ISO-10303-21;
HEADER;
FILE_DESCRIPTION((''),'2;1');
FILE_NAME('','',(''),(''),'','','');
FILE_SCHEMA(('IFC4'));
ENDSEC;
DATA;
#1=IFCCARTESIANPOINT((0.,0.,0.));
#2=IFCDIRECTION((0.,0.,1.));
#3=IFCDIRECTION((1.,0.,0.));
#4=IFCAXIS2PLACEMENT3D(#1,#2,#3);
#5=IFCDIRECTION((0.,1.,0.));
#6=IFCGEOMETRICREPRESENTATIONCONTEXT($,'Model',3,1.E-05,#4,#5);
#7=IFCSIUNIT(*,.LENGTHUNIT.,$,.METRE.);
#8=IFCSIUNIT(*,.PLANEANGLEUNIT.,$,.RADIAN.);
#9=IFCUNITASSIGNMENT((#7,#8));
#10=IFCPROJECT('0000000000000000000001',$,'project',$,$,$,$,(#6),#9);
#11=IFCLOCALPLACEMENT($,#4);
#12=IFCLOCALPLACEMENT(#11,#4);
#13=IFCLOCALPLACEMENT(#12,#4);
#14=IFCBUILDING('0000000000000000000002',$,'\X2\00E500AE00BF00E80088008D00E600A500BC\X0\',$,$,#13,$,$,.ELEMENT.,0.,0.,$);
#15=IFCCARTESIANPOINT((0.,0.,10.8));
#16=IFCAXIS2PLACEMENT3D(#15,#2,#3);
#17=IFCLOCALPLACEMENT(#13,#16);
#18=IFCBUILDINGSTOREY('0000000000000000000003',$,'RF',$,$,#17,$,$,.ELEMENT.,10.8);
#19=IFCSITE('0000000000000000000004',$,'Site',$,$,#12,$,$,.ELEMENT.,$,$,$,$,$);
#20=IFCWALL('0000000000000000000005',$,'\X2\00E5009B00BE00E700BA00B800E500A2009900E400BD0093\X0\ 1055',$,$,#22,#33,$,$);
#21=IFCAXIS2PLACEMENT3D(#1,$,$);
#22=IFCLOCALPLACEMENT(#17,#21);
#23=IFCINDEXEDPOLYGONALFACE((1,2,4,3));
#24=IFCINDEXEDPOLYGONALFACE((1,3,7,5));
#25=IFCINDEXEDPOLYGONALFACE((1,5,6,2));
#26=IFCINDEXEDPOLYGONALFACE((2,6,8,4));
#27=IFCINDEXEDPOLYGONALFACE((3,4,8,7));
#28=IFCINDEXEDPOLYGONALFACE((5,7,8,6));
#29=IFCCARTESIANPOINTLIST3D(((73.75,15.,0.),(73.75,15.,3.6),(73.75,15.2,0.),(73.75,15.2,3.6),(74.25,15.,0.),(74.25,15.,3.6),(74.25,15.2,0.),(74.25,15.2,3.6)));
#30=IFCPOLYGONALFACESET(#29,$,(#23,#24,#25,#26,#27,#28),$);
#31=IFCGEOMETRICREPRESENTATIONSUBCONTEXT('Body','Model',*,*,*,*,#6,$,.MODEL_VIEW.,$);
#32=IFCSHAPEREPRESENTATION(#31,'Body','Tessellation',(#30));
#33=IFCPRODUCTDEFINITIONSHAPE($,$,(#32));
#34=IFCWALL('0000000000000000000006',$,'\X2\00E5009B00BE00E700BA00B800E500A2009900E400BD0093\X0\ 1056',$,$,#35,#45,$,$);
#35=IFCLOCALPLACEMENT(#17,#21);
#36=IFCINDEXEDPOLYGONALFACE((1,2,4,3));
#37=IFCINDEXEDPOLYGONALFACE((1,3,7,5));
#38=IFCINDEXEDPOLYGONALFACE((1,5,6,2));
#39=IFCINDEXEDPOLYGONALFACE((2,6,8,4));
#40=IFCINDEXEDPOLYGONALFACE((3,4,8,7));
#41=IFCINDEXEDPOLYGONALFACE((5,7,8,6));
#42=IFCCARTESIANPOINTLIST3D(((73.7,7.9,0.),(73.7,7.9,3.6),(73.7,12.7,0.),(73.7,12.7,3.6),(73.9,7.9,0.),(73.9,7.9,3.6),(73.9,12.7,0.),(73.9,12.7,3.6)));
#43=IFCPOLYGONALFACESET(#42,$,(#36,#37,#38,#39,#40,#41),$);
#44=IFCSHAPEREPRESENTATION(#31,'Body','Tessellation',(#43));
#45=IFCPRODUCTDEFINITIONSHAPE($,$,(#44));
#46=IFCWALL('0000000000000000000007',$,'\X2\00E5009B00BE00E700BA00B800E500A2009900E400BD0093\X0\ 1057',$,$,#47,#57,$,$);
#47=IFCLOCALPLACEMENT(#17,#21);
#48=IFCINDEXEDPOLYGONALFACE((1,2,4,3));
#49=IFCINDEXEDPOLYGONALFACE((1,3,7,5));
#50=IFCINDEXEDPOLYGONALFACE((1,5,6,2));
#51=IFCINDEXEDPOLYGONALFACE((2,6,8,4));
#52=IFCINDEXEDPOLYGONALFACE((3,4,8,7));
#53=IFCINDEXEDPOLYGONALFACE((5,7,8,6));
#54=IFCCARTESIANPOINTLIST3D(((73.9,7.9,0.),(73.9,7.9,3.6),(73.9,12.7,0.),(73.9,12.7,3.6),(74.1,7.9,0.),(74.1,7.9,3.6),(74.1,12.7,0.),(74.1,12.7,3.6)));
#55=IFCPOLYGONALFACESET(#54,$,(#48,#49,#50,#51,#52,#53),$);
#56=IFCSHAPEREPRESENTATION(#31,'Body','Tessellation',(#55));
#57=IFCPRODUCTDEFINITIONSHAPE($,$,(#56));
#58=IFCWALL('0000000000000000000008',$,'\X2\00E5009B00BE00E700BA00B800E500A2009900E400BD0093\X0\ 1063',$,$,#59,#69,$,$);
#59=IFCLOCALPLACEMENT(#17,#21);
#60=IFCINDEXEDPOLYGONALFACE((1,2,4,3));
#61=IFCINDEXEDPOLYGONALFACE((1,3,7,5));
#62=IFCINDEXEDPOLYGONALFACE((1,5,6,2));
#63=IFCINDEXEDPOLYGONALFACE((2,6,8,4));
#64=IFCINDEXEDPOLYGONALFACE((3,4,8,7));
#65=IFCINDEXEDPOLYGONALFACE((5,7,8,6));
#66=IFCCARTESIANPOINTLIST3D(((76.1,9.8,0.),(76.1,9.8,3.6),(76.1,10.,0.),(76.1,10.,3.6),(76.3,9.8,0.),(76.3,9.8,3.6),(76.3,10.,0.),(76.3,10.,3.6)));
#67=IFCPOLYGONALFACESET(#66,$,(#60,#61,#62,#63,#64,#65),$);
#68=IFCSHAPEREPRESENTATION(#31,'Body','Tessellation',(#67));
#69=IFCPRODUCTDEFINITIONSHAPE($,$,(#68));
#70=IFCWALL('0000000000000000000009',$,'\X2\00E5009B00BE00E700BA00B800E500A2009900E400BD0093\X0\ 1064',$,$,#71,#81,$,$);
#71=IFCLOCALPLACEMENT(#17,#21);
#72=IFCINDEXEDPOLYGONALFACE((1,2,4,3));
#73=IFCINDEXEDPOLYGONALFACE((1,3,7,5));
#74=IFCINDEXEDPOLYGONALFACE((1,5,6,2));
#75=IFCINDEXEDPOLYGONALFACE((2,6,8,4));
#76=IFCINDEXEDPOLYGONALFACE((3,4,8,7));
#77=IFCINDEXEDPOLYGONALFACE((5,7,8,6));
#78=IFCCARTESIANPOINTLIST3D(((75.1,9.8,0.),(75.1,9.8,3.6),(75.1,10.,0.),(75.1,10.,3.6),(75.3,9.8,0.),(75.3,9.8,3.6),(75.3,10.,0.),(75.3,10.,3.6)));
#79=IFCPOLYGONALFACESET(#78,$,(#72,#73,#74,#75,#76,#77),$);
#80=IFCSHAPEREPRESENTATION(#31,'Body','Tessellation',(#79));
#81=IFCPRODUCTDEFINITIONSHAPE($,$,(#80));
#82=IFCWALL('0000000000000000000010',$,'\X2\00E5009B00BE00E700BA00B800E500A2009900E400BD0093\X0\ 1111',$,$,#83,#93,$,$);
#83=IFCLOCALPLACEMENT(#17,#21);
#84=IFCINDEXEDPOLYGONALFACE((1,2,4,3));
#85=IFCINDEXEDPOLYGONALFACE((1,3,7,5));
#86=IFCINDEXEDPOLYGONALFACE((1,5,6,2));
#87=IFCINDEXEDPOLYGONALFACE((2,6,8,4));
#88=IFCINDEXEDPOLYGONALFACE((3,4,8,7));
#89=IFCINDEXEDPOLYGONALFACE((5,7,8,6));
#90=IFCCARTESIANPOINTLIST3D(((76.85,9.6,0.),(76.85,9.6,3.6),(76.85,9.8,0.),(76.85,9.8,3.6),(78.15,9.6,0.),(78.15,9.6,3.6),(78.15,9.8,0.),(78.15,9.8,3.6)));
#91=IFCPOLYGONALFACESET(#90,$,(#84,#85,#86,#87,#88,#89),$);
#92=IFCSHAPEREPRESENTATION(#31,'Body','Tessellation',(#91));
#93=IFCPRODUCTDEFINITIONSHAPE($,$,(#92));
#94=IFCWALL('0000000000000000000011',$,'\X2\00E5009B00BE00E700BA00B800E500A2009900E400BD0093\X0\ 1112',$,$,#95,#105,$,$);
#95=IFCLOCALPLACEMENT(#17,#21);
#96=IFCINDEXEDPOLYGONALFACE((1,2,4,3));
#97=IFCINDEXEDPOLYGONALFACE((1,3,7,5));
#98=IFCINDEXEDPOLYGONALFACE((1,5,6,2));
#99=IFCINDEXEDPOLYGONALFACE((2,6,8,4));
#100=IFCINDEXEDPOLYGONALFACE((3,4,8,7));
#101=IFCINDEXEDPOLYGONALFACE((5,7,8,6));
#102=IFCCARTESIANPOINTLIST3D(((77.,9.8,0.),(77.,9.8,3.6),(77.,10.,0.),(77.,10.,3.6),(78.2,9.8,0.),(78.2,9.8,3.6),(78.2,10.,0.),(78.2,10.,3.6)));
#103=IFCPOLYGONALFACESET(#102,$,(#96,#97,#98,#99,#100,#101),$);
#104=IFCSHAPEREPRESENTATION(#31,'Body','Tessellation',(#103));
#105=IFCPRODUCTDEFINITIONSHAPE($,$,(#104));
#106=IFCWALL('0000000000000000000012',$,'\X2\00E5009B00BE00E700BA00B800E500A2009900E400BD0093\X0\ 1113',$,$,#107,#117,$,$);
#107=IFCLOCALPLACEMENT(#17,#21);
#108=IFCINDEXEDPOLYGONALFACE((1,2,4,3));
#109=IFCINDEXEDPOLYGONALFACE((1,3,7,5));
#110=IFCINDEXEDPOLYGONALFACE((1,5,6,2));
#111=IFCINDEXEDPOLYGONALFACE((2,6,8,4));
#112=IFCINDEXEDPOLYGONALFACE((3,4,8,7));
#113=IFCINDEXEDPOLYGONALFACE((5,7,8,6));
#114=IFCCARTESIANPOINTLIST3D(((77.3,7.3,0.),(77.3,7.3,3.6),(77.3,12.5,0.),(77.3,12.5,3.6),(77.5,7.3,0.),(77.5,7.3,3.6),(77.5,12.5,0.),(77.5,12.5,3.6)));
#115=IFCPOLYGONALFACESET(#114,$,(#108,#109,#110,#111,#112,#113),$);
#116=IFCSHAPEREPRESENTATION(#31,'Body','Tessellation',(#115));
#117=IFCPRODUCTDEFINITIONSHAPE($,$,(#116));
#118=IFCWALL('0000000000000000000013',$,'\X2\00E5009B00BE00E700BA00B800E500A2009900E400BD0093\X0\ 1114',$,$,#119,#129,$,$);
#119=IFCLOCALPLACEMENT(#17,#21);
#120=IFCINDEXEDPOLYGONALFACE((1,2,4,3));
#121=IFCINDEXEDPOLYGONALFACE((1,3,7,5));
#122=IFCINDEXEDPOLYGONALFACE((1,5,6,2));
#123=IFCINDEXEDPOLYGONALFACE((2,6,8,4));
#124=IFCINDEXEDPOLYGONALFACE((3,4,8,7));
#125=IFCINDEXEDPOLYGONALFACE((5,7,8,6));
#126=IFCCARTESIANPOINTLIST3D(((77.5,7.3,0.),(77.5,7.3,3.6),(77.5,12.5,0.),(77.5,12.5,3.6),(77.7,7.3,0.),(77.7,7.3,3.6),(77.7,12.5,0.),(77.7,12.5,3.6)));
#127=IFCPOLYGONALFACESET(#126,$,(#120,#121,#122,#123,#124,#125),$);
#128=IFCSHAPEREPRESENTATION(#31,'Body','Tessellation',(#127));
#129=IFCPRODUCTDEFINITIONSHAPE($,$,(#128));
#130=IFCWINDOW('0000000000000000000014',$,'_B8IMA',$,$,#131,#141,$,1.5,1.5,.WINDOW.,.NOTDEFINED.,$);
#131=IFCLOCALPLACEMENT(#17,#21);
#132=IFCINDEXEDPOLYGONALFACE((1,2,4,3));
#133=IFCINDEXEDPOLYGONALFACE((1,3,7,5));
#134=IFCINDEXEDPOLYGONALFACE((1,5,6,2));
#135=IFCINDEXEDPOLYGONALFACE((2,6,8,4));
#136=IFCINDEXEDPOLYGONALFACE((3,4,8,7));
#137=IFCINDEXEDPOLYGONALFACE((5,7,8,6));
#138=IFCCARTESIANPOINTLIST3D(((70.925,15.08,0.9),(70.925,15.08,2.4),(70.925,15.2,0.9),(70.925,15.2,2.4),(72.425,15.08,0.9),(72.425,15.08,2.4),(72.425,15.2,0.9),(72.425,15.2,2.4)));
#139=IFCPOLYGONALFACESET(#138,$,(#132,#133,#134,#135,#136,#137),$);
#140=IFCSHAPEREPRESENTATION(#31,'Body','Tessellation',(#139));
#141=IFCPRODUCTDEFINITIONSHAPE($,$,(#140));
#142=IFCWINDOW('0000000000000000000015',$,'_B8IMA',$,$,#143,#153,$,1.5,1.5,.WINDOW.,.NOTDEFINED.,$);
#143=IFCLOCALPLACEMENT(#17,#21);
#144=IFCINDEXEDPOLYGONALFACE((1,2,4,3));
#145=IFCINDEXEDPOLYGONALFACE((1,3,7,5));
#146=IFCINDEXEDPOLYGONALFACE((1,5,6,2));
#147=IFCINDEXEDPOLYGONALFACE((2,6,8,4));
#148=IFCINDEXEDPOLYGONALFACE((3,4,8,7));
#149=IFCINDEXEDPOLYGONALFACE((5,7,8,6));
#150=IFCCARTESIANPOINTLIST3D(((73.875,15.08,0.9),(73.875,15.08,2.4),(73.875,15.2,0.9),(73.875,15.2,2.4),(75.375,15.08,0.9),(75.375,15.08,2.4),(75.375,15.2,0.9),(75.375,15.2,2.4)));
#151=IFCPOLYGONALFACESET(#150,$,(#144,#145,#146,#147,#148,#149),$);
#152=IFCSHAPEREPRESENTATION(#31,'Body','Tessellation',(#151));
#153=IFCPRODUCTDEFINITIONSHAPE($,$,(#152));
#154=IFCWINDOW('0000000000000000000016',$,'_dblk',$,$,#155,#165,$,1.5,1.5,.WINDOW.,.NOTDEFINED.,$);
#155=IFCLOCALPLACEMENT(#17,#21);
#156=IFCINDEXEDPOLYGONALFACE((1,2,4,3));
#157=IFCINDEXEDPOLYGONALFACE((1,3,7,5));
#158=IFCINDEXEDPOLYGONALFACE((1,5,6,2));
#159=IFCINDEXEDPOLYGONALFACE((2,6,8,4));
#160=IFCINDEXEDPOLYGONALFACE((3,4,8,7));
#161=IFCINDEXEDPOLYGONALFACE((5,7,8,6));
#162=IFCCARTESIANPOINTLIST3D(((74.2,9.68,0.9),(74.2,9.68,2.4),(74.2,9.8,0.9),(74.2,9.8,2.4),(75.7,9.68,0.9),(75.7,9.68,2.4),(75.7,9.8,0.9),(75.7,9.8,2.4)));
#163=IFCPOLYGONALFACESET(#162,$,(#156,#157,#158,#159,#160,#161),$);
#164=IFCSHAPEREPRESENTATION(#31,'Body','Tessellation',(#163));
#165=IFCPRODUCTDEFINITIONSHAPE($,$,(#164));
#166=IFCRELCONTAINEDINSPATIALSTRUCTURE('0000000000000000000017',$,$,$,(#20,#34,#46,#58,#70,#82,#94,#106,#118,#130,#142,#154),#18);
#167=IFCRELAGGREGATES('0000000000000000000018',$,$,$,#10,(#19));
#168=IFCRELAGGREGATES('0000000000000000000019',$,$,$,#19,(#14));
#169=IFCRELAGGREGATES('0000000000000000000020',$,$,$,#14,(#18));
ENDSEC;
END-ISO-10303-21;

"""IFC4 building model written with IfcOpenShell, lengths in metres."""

from ifc_helpers import new_model, si_unit, direction, frame, frame_2d, origin_with_axes, place, context, subcontext, project, spatial, rectangle, extrude, element, save


model = new_model("IFC4")

# Units and contexts
model_context = context("Model", 3, precision=1e-05, world=origin_with_axes(), true_north=direction((0.0, 1.0, 0.0)))
body_context = subcontext(model_context, "Body", "Model", "MODEL_VIEW")
ifc_project = project(units=[si_unit("LENGTHUNIT", "METRE"), si_unit("PLANEANGLEUNIT", "RADIAN")], contexts=[model_context])

# Site, building, storey
placement = place(None, origin_with_axes())
site_placement = place(placement, origin_with_axes())
site = spatial("IfcSite", under=ifc_project, at=site_placement, Name="Site", CompositionType="ELEMENT")
building_placement = place(site_placement, origin_with_axes())
building = spatial("IfcBuilding", under=site, at=building_placement, Name="å®¿è\u0088\u008dæ¥¼", CompositionType="ELEMENT", ElevationOfRefHeight=0.0, ElevationOfTerrain=0.0)
storey_placement = place(building_placement, frame((0.0, 0.0, 10.8), z_axis=(0.0, 0.0, 1.0), x_axis=(1.0, 0.0, 0.0)))
storey = spatial("IfcBuildingStorey", under=building, at=storey_placement, Name="RF", CompositionType="ELEMENT", Elevation=10.8)

# Walls
for number, where, z_axis, x_axis, name in (
    (1, (74.0, 15.1, 0.0), (0.0, 0.0, 1.0), (1.0, 0.0, 0.0), "å\u009b¾çº¸å¢\u0099ä½\u0093 1055"),
):
    element("IfcWall", number, at=place(storey_placement, frame(where, z_axis=z_axis, x_axis=x_axis)), inside=storey, Name=name, context=body_context, shape_type="SweptSolid", body=[
        extrude(rectangle(XDim=0.5, YDim=0.2, at=frame_2d((0.0, 0.0), x_axis=(1.0, 0.0, 0.0))), frame((0.0, 0.0, 0.0), z_axis=(0.0, 0.0, 1.0)), (0.0, 0.0, 1.0), 3.6),
    ])
for number, where, z_axis, x_axis, name in (
    (2, (73.8, 10.3, 0.0), (0.0, 0.0, 1.0), (0.0, 1.0, 0.0), "å\u009b¾çº¸å¢\u0099ä½\u0093 1056"),
    (3, (74.0, 10.3, 0.0), (0.0, 0.0, 1.0), (0.0, 1.0, 0.0), "å\u009b¾çº¸å¢\u0099ä½\u0093 1057"),
):
    element("IfcWall", number, at=place(storey_placement, frame(where, z_axis=z_axis, x_axis=x_axis)), inside=storey, Name=name, context=body_context, shape_type="SweptSolid", body=[
        extrude(rectangle(XDim=4.8, YDim=0.2, at=frame_2d((0.0, 0.0), x_axis=(1.0, 0.0, 0.0))), frame((0.0, 0.0, 0.0), z_axis=(0.0, 0.0, 1.0)), (0.0, 0.0, 1.0), 3.6),
    ])
for number, where, z_axis, x_axis, name in (
    (4, (76.2, 9.9, 0.0), (0.0, 0.0, 1.0), (0.0, -1.0, 0.0), "å\u009b¾çº¸å¢\u0099ä½\u0093 1063"),
    (5, (75.2, 9.9, 0.0), (0.0, 0.0, 1.0), (0.0, -1.0, 0.0), "å\u009b¾çº¸å¢\u0099ä½\u0093 1064"),
):
    element("IfcWall", number, at=place(storey_placement, frame(where, z_axis=z_axis, x_axis=x_axis)), inside=storey, Name=name, context=body_context, shape_type="SweptSolid", body=[
        extrude(rectangle(XDim=0.2, YDim=0.2, at=frame_2d((0.0, 0.0), x_axis=(1.0, 0.0, 0.0))), frame((0.0, 0.0, 0.0), z_axis=(0.0, 0.0, 1.0)), (0.0, 0.0, 1.0), 3.6),
    ])
wall_1_placement = place(storey_placement, frame((77.5, 9.7, 0.0), z_axis=(0.0, 0.0, 1.0), x_axis=(1.0, 0.0, 0.0)))
element("IfcWall", 6, at=wall_1_placement, inside=storey, Name="å\u009b¾çº¸å¢\u0099ä½\u0093 1111", context=body_context, shape_type="SweptSolid", body=[
    extrude(rectangle(XDim=1.3, YDim=0.2, at=frame_2d((0.0, 0.0), x_axis=(1.0, 0.0, 0.0))), frame((0.0, 0.0, 0.0), z_axis=(0.0, 0.0, 1.0)), (0.0, 0.0, 1.0), 3.6),
])
wall_2_placement = place(storey_placement, frame((77.6, 9.9, 0.0), z_axis=(0.0, 0.0, 1.0), x_axis=(1.0, 0.0, 0.0)))
element("IfcWall", 7, at=wall_2_placement, inside=storey, Name="å\u009b¾çº¸å¢\u0099ä½\u0093 1112", context=body_context, shape_type="SweptSolid", body=[
    extrude(rectangle(XDim=1.2, YDim=0.2, at=frame_2d((0.0, 0.0), x_axis=(1.0, 0.0, 0.0))), frame((0.0, 0.0, 0.0), z_axis=(0.0, 0.0, 1.0)), (0.0, 0.0, 1.0), 3.6),
])
for number, where, z_axis, x_axis, name in (
    (8, (77.4, 9.9, 0.0), (0.0, 0.0, 1.0), (0.0, 1.0, 0.0), "å\u009b¾çº¸å¢\u0099ä½\u0093 1113"),
    (9, (77.6, 9.9, 0.0), (0.0, 0.0, 1.0), (0.0, 1.0, 0.0), "å\u009b¾çº¸å¢\u0099ä½\u0093 1114"),
):
    element("IfcWall", number, at=place(storey_placement, frame(where, z_axis=z_axis, x_axis=x_axis)), inside=storey, Name=name, context=body_context, shape_type="SweptSolid", body=[
        extrude(rectangle(XDim=5.2, YDim=0.2, at=frame_2d((0.0, 0.0), x_axis=(1.0, 0.0, 0.0))), frame((0.0, 0.0, 0.0), z_axis=(0.0, 0.0, 1.0)), (0.0, 0.0, 1.0), 3.6),
    ])

# Windows
for number, where, z_axis, x_axis, name in (
    (10, (71.675, 15.14, 0.9), (0.0, 0.0, 1.0), (1.0, 0.0, 0.0), "_B8IMA"),
    (11, (74.625, 15.14, 0.9), (0.0, 0.0, 1.0), (1.0, 0.0, 0.0), "_B8IMA"),
    (12, (74.95, 9.74, 0.9), (0.0, 0.0, 1.0), (1.0, 0.0, 0.0), "_dblk"),
):
    element("IfcWindow", number, at=place(storey_placement, frame(where, z_axis=z_axis, x_axis=x_axis)), inside=storey, Name=name, OverallHeight=1.5, OverallWidth=1.5, PartitioningType="NOTDEFINED", PredefinedType="WINDOW", context=body_context, shape_type="SweptSolid", body=[
        extrude(rectangle(XDim=1.5, YDim=0.12, at=frame_2d((0.0, 0.0), x_axis=(1.0, 0.0, 0.0))), frame((0.0, 0.0, 0.0), z_axis=(0.0, 0.0, 1.0)), (0.0, 0.0, 1.0), 1.5),
    ])

save(model, "model.ifc")
